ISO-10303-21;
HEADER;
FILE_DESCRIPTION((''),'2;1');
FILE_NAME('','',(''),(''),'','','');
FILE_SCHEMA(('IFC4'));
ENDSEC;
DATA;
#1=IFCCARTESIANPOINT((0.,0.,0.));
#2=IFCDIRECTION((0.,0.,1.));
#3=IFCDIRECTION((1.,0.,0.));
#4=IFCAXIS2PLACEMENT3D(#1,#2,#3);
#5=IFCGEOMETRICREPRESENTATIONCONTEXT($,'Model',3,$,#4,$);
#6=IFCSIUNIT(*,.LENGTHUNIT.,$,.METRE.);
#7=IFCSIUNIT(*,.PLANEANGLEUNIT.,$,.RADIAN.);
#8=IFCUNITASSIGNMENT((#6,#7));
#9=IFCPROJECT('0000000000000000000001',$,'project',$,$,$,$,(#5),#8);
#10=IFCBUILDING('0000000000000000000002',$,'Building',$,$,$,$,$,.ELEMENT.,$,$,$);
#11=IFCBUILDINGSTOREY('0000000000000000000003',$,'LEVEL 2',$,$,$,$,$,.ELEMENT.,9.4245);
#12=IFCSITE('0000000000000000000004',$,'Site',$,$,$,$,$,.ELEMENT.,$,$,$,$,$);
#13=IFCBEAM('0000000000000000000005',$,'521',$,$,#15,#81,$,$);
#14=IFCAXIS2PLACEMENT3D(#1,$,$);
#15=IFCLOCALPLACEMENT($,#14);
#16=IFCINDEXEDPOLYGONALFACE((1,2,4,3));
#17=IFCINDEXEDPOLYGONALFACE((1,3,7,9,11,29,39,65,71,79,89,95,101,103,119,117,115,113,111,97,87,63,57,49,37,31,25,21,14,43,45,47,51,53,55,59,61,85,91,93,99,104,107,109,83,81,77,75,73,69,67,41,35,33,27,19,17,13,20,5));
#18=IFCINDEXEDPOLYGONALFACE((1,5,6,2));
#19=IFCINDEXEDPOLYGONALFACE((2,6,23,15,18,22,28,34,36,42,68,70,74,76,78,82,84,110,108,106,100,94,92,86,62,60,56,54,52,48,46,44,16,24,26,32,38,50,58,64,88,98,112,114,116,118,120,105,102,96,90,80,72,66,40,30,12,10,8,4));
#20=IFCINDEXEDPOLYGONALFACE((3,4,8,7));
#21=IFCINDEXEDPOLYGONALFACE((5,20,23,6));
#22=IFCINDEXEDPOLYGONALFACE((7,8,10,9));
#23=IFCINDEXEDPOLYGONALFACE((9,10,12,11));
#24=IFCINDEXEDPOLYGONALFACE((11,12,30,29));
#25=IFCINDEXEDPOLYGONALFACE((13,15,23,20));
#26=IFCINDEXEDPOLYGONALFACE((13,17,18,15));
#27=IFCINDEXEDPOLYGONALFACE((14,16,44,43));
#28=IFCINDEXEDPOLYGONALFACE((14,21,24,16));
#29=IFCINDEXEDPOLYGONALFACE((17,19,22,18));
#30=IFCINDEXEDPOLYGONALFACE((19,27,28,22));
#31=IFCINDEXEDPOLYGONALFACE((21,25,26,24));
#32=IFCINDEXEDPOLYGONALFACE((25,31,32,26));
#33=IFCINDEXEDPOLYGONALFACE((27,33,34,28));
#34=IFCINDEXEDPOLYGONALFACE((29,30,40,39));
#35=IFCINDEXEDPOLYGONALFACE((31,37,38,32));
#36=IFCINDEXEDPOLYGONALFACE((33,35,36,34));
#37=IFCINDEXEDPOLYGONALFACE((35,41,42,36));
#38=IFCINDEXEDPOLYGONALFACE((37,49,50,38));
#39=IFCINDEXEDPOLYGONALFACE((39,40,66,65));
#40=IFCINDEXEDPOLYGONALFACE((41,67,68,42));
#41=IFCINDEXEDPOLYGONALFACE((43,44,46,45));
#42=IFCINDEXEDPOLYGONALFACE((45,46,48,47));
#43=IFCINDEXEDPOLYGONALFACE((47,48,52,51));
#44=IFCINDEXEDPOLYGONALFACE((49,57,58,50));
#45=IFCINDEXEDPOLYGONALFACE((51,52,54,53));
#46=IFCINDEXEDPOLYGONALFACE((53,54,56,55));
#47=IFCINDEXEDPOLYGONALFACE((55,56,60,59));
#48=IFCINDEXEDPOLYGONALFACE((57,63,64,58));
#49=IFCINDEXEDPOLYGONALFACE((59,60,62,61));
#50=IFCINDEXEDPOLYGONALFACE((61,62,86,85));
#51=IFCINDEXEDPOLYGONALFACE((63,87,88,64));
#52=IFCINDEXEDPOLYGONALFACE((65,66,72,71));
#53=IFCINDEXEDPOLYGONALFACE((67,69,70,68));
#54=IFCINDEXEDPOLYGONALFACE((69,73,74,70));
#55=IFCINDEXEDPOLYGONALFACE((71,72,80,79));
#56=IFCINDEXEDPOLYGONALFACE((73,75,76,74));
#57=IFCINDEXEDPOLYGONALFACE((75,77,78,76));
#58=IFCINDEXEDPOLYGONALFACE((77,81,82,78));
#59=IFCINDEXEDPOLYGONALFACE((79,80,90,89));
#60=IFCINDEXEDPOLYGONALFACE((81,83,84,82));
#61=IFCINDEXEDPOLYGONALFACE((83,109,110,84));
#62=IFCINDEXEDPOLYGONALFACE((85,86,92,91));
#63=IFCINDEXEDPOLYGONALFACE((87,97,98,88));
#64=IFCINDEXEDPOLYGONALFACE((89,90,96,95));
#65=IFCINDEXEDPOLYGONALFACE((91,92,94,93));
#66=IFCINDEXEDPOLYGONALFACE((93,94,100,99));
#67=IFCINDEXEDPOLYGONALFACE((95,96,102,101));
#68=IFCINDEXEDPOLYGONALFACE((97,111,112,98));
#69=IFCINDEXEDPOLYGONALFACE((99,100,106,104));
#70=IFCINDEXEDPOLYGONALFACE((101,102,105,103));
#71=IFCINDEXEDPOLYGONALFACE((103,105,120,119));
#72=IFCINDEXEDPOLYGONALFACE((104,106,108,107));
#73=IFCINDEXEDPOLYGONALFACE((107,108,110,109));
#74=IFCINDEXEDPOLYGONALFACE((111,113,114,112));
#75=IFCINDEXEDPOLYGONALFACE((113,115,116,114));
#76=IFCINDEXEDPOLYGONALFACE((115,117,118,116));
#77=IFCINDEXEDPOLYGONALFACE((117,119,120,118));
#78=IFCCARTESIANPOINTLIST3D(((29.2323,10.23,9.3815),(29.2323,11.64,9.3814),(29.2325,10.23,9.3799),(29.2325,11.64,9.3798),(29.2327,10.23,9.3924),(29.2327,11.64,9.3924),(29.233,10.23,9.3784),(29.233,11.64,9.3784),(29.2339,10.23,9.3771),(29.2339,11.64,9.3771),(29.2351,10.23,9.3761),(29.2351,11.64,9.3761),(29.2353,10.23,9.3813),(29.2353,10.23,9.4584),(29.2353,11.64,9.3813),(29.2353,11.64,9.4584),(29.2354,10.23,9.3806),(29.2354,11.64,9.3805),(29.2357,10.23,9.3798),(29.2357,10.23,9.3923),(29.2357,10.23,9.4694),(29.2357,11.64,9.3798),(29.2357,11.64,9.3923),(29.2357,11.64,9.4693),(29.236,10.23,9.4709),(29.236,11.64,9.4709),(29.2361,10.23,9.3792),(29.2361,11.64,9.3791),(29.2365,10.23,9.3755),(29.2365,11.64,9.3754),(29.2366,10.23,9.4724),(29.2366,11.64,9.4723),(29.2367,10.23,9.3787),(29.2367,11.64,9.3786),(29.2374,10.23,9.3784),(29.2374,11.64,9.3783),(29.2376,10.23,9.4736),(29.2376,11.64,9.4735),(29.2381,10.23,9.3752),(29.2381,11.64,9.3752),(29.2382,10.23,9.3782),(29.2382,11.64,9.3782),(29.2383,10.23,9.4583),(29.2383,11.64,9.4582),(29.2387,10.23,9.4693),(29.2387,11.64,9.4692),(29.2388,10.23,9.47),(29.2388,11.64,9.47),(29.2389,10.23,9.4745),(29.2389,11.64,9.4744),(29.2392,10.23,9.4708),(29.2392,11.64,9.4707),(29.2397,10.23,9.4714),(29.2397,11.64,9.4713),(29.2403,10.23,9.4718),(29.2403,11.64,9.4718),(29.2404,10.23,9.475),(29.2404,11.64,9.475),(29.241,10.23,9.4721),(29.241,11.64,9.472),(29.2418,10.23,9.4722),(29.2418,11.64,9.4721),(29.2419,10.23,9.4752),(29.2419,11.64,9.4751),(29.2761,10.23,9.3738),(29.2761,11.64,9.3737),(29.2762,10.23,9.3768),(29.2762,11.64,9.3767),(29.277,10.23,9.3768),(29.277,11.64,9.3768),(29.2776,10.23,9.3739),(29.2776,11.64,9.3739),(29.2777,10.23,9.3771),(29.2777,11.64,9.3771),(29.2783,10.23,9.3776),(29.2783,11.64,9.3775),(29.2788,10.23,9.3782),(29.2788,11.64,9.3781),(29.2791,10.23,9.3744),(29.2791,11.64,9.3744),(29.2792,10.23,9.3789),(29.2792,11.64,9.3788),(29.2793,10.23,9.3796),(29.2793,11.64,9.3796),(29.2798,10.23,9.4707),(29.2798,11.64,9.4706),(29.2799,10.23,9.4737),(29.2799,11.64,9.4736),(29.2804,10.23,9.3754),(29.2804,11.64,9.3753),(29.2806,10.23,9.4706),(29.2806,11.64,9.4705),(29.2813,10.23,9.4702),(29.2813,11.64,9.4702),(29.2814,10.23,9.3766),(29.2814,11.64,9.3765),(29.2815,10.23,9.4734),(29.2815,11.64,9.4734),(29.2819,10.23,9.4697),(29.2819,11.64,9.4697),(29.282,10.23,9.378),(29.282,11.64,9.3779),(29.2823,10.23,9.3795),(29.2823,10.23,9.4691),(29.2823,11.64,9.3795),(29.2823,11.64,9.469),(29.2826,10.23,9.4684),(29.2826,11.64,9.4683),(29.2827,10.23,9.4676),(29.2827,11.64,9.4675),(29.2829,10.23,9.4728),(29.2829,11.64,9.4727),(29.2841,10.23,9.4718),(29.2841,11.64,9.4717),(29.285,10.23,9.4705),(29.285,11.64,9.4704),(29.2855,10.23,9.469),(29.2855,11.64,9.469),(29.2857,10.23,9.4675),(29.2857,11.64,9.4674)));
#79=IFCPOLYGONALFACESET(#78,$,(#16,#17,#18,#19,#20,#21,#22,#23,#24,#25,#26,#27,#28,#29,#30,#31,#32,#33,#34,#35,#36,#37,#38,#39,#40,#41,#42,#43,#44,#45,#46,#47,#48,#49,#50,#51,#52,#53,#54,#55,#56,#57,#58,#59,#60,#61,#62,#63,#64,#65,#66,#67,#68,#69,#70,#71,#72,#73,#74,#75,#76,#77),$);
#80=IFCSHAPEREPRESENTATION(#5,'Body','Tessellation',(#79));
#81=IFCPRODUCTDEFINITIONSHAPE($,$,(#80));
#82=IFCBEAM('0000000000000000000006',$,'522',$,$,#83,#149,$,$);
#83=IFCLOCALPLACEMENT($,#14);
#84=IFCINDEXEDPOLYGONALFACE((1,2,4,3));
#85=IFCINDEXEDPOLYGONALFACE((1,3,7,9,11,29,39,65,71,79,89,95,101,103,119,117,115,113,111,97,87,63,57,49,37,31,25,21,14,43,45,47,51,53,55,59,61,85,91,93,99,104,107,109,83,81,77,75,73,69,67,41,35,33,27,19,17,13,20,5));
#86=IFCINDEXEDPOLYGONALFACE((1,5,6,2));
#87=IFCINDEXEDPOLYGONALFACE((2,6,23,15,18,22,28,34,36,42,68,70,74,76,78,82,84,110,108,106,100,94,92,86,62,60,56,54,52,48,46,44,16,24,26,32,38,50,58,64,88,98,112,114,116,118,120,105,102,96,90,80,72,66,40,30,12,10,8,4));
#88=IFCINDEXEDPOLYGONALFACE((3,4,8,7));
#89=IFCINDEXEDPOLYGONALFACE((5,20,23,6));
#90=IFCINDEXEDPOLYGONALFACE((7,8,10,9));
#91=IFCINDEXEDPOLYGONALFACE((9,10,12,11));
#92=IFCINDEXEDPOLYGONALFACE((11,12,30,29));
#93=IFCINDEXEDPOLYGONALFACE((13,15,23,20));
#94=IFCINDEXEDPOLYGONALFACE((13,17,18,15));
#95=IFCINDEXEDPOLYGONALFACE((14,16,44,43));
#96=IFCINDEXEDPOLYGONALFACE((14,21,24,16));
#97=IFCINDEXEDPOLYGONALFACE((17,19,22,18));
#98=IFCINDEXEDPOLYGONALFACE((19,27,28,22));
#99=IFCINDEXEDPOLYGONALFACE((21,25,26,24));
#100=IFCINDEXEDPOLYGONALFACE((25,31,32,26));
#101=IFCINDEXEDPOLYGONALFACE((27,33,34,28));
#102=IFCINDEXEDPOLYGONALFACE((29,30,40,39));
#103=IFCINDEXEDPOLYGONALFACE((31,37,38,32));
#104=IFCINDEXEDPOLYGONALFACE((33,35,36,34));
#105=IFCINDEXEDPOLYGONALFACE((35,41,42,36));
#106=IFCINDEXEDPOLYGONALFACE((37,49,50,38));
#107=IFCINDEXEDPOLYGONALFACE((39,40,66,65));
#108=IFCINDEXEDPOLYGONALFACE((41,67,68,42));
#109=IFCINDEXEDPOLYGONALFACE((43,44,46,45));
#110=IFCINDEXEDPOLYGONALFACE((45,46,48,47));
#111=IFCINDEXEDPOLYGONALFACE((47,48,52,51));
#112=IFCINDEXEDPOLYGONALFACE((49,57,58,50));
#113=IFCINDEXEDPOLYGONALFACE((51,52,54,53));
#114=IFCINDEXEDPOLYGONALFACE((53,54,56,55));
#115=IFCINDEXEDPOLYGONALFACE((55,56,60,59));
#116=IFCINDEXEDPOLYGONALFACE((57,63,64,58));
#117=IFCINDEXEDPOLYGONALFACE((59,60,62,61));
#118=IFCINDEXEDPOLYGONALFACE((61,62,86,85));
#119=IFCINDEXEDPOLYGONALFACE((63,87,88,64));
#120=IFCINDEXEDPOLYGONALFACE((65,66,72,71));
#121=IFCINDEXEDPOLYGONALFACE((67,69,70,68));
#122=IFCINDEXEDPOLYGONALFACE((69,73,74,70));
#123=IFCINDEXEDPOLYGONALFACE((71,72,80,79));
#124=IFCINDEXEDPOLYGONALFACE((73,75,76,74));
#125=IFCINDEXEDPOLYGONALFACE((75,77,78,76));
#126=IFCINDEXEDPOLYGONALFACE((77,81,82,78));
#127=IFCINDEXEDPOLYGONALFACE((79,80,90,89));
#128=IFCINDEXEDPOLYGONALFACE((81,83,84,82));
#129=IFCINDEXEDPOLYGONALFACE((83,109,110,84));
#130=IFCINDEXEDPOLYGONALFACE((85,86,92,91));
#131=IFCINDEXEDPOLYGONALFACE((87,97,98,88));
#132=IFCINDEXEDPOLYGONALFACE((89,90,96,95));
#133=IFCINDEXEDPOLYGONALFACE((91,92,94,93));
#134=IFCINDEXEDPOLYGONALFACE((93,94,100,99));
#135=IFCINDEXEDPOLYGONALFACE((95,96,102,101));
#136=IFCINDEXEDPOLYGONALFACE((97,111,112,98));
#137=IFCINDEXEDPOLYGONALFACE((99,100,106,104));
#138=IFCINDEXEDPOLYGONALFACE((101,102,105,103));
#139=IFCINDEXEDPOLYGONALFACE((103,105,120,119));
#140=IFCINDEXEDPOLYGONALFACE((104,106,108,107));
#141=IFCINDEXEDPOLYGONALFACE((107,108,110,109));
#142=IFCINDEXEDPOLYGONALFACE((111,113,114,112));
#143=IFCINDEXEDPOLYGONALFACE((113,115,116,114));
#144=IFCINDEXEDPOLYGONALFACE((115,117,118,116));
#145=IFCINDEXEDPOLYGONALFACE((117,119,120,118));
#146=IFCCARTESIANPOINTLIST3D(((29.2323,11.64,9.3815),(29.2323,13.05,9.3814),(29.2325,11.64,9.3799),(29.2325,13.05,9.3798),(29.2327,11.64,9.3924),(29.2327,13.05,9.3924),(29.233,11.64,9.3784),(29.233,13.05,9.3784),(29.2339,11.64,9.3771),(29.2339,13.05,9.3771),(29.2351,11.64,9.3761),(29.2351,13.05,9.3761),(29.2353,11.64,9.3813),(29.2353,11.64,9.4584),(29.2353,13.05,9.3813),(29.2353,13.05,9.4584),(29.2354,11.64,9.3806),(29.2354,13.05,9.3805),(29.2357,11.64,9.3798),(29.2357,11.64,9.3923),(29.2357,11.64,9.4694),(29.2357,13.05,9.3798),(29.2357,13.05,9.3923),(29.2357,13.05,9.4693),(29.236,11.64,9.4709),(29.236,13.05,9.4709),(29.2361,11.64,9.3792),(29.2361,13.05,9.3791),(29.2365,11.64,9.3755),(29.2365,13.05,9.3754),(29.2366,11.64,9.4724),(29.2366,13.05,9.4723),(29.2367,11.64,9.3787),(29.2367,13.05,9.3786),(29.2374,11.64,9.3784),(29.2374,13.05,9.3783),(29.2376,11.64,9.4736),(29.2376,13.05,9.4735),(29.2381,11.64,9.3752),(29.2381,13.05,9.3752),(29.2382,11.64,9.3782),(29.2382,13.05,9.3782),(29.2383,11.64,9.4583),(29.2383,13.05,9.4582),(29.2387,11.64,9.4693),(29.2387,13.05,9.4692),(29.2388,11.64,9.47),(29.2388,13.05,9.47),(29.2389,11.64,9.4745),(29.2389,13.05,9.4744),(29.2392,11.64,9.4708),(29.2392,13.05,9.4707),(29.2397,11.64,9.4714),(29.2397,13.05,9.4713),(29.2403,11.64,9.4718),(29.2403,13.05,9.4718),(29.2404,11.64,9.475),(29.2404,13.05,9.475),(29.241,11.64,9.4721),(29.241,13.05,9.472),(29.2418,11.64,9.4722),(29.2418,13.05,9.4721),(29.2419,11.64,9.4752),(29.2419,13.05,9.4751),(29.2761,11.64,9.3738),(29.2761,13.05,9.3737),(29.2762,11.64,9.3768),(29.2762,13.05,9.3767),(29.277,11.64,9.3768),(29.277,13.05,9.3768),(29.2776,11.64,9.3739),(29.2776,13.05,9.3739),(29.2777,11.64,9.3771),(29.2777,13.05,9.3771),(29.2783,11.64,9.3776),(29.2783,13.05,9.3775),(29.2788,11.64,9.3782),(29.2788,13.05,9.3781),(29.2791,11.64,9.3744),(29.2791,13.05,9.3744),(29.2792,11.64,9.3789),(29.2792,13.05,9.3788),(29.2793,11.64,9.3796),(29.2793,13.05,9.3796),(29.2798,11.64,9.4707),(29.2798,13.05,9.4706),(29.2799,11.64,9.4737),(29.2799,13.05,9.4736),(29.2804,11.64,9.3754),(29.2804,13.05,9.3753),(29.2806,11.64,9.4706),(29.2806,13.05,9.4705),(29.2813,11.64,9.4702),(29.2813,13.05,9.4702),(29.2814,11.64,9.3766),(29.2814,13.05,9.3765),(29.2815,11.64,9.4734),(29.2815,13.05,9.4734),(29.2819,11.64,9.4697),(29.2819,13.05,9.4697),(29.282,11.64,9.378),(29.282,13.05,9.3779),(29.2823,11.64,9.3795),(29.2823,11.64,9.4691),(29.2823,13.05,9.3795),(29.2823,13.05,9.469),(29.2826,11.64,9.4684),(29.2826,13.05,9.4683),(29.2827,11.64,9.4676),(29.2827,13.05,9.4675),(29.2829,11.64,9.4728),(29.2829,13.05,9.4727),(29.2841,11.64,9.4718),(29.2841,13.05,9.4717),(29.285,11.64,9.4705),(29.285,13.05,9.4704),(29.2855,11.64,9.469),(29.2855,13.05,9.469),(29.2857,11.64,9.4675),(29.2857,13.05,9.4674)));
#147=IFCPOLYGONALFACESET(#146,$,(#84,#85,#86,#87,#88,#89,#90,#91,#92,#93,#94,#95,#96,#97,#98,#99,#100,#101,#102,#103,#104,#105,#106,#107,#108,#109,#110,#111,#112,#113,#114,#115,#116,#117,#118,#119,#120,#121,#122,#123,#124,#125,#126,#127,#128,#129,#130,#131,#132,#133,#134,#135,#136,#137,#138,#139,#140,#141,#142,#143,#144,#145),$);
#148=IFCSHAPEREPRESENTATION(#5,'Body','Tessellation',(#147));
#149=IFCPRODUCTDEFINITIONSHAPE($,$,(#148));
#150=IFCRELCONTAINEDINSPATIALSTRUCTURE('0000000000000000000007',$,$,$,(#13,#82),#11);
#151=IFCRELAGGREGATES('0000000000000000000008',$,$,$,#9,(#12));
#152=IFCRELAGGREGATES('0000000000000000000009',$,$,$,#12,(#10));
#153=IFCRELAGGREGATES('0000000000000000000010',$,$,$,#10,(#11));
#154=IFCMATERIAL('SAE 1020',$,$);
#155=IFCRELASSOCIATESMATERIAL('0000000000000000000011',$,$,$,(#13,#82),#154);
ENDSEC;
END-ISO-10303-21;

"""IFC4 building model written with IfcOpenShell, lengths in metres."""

from ifc_helpers import new_model, si_unit, frame, origin_with_axes, origin_2d_with_axis, place, context, project, spatial, c_section, extrude, material, material_profile, profile_set, profile_usage, element, save


model = new_model("IFC4")

# Units and contexts
model_context = context("Model", 3, world=origin_with_axes())
ifc_project = project(units=[si_unit("LENGTHUNIT", "METRE"), si_unit("PLANEANGLEUNIT", "RADIAN")], contexts=[model_context])

# Site, building, storey
site = spatial("IfcSite", under=ifc_project, Name="Site", CompositionType="ELEMENT")
building = spatial("IfcBuilding", under=site, Name="Building", CompositionType="ELEMENT")
storey = spatial("IfcBuildingStorey", under=building, Name="LEVEL 2", CompositionType="ELEMENT", Elevation=9.4245)

# Beams
ifc_material = material(Name="SAE 1020")
ifc_material_profile_1 = material_profile(ifc_material, c_section(Depth=0.1, Width=0.05, WallThickness=0.003, Girth=0.017, InternalFilletRadius=0.003, at=origin_2d_with_axis()))
ifc_profile_set_1 = profile_set([ifc_material_profile_1])
ifc_profile_usage_1 = profile_usage(ifc_profile_set_1, cardinal=10)
beam_1_placement = place(None, frame((29.259, 10.23, 9.4245), z_axis=(0.0, 1.0, -0.00003), x_axis=(-0.999256, 0.000001, 0.038562)))
element("IfcBeam", 1, at=beam_1_placement, inside=storey, material=ifc_profile_usage_1, Name="521", context=model_context, shape_type="SweptSolid", body=[
    extrude(c_section(Depth=0.1, Width=0.05, WallThickness=0.003, Girth=0.017, InternalFilletRadius=0.003, at=origin_2d_with_axis()), origin_with_axes(), (0.0, 0.0, 1.0), 1.41),
])
ifc_material_profile_2 = material_profile(ifc_material, c_section(Depth=0.1, Width=0.05, WallThickness=0.003, Girth=0.017, InternalFilletRadius=0.003, at=origin_2d_with_axis()))
ifc_profile_set_2 = profile_set([ifc_material_profile_2])
ifc_profile_usage_2 = profile_usage(ifc_profile_set_2, cardinal=10)
beam_2_placement = place(None, frame((29.259, 11.64, 9.4245), z_axis=(0.0, 1.0, -0.00003), x_axis=(-0.999256, 0.000001, 0.038562)))
element("IfcBeam", 2, at=beam_2_placement, inside=storey, material=ifc_profile_usage_2, Name="522", context=model_context, shape_type="SweptSolid", body=[
    extrude(c_section(Depth=0.1, Width=0.05, WallThickness=0.003, Girth=0.017, InternalFilletRadius=0.003, at=origin_2d_with_axis()), origin_with_axes(), (0.0, 0.0, 1.0), 1.41),
])

save(model, "model.ifc")
